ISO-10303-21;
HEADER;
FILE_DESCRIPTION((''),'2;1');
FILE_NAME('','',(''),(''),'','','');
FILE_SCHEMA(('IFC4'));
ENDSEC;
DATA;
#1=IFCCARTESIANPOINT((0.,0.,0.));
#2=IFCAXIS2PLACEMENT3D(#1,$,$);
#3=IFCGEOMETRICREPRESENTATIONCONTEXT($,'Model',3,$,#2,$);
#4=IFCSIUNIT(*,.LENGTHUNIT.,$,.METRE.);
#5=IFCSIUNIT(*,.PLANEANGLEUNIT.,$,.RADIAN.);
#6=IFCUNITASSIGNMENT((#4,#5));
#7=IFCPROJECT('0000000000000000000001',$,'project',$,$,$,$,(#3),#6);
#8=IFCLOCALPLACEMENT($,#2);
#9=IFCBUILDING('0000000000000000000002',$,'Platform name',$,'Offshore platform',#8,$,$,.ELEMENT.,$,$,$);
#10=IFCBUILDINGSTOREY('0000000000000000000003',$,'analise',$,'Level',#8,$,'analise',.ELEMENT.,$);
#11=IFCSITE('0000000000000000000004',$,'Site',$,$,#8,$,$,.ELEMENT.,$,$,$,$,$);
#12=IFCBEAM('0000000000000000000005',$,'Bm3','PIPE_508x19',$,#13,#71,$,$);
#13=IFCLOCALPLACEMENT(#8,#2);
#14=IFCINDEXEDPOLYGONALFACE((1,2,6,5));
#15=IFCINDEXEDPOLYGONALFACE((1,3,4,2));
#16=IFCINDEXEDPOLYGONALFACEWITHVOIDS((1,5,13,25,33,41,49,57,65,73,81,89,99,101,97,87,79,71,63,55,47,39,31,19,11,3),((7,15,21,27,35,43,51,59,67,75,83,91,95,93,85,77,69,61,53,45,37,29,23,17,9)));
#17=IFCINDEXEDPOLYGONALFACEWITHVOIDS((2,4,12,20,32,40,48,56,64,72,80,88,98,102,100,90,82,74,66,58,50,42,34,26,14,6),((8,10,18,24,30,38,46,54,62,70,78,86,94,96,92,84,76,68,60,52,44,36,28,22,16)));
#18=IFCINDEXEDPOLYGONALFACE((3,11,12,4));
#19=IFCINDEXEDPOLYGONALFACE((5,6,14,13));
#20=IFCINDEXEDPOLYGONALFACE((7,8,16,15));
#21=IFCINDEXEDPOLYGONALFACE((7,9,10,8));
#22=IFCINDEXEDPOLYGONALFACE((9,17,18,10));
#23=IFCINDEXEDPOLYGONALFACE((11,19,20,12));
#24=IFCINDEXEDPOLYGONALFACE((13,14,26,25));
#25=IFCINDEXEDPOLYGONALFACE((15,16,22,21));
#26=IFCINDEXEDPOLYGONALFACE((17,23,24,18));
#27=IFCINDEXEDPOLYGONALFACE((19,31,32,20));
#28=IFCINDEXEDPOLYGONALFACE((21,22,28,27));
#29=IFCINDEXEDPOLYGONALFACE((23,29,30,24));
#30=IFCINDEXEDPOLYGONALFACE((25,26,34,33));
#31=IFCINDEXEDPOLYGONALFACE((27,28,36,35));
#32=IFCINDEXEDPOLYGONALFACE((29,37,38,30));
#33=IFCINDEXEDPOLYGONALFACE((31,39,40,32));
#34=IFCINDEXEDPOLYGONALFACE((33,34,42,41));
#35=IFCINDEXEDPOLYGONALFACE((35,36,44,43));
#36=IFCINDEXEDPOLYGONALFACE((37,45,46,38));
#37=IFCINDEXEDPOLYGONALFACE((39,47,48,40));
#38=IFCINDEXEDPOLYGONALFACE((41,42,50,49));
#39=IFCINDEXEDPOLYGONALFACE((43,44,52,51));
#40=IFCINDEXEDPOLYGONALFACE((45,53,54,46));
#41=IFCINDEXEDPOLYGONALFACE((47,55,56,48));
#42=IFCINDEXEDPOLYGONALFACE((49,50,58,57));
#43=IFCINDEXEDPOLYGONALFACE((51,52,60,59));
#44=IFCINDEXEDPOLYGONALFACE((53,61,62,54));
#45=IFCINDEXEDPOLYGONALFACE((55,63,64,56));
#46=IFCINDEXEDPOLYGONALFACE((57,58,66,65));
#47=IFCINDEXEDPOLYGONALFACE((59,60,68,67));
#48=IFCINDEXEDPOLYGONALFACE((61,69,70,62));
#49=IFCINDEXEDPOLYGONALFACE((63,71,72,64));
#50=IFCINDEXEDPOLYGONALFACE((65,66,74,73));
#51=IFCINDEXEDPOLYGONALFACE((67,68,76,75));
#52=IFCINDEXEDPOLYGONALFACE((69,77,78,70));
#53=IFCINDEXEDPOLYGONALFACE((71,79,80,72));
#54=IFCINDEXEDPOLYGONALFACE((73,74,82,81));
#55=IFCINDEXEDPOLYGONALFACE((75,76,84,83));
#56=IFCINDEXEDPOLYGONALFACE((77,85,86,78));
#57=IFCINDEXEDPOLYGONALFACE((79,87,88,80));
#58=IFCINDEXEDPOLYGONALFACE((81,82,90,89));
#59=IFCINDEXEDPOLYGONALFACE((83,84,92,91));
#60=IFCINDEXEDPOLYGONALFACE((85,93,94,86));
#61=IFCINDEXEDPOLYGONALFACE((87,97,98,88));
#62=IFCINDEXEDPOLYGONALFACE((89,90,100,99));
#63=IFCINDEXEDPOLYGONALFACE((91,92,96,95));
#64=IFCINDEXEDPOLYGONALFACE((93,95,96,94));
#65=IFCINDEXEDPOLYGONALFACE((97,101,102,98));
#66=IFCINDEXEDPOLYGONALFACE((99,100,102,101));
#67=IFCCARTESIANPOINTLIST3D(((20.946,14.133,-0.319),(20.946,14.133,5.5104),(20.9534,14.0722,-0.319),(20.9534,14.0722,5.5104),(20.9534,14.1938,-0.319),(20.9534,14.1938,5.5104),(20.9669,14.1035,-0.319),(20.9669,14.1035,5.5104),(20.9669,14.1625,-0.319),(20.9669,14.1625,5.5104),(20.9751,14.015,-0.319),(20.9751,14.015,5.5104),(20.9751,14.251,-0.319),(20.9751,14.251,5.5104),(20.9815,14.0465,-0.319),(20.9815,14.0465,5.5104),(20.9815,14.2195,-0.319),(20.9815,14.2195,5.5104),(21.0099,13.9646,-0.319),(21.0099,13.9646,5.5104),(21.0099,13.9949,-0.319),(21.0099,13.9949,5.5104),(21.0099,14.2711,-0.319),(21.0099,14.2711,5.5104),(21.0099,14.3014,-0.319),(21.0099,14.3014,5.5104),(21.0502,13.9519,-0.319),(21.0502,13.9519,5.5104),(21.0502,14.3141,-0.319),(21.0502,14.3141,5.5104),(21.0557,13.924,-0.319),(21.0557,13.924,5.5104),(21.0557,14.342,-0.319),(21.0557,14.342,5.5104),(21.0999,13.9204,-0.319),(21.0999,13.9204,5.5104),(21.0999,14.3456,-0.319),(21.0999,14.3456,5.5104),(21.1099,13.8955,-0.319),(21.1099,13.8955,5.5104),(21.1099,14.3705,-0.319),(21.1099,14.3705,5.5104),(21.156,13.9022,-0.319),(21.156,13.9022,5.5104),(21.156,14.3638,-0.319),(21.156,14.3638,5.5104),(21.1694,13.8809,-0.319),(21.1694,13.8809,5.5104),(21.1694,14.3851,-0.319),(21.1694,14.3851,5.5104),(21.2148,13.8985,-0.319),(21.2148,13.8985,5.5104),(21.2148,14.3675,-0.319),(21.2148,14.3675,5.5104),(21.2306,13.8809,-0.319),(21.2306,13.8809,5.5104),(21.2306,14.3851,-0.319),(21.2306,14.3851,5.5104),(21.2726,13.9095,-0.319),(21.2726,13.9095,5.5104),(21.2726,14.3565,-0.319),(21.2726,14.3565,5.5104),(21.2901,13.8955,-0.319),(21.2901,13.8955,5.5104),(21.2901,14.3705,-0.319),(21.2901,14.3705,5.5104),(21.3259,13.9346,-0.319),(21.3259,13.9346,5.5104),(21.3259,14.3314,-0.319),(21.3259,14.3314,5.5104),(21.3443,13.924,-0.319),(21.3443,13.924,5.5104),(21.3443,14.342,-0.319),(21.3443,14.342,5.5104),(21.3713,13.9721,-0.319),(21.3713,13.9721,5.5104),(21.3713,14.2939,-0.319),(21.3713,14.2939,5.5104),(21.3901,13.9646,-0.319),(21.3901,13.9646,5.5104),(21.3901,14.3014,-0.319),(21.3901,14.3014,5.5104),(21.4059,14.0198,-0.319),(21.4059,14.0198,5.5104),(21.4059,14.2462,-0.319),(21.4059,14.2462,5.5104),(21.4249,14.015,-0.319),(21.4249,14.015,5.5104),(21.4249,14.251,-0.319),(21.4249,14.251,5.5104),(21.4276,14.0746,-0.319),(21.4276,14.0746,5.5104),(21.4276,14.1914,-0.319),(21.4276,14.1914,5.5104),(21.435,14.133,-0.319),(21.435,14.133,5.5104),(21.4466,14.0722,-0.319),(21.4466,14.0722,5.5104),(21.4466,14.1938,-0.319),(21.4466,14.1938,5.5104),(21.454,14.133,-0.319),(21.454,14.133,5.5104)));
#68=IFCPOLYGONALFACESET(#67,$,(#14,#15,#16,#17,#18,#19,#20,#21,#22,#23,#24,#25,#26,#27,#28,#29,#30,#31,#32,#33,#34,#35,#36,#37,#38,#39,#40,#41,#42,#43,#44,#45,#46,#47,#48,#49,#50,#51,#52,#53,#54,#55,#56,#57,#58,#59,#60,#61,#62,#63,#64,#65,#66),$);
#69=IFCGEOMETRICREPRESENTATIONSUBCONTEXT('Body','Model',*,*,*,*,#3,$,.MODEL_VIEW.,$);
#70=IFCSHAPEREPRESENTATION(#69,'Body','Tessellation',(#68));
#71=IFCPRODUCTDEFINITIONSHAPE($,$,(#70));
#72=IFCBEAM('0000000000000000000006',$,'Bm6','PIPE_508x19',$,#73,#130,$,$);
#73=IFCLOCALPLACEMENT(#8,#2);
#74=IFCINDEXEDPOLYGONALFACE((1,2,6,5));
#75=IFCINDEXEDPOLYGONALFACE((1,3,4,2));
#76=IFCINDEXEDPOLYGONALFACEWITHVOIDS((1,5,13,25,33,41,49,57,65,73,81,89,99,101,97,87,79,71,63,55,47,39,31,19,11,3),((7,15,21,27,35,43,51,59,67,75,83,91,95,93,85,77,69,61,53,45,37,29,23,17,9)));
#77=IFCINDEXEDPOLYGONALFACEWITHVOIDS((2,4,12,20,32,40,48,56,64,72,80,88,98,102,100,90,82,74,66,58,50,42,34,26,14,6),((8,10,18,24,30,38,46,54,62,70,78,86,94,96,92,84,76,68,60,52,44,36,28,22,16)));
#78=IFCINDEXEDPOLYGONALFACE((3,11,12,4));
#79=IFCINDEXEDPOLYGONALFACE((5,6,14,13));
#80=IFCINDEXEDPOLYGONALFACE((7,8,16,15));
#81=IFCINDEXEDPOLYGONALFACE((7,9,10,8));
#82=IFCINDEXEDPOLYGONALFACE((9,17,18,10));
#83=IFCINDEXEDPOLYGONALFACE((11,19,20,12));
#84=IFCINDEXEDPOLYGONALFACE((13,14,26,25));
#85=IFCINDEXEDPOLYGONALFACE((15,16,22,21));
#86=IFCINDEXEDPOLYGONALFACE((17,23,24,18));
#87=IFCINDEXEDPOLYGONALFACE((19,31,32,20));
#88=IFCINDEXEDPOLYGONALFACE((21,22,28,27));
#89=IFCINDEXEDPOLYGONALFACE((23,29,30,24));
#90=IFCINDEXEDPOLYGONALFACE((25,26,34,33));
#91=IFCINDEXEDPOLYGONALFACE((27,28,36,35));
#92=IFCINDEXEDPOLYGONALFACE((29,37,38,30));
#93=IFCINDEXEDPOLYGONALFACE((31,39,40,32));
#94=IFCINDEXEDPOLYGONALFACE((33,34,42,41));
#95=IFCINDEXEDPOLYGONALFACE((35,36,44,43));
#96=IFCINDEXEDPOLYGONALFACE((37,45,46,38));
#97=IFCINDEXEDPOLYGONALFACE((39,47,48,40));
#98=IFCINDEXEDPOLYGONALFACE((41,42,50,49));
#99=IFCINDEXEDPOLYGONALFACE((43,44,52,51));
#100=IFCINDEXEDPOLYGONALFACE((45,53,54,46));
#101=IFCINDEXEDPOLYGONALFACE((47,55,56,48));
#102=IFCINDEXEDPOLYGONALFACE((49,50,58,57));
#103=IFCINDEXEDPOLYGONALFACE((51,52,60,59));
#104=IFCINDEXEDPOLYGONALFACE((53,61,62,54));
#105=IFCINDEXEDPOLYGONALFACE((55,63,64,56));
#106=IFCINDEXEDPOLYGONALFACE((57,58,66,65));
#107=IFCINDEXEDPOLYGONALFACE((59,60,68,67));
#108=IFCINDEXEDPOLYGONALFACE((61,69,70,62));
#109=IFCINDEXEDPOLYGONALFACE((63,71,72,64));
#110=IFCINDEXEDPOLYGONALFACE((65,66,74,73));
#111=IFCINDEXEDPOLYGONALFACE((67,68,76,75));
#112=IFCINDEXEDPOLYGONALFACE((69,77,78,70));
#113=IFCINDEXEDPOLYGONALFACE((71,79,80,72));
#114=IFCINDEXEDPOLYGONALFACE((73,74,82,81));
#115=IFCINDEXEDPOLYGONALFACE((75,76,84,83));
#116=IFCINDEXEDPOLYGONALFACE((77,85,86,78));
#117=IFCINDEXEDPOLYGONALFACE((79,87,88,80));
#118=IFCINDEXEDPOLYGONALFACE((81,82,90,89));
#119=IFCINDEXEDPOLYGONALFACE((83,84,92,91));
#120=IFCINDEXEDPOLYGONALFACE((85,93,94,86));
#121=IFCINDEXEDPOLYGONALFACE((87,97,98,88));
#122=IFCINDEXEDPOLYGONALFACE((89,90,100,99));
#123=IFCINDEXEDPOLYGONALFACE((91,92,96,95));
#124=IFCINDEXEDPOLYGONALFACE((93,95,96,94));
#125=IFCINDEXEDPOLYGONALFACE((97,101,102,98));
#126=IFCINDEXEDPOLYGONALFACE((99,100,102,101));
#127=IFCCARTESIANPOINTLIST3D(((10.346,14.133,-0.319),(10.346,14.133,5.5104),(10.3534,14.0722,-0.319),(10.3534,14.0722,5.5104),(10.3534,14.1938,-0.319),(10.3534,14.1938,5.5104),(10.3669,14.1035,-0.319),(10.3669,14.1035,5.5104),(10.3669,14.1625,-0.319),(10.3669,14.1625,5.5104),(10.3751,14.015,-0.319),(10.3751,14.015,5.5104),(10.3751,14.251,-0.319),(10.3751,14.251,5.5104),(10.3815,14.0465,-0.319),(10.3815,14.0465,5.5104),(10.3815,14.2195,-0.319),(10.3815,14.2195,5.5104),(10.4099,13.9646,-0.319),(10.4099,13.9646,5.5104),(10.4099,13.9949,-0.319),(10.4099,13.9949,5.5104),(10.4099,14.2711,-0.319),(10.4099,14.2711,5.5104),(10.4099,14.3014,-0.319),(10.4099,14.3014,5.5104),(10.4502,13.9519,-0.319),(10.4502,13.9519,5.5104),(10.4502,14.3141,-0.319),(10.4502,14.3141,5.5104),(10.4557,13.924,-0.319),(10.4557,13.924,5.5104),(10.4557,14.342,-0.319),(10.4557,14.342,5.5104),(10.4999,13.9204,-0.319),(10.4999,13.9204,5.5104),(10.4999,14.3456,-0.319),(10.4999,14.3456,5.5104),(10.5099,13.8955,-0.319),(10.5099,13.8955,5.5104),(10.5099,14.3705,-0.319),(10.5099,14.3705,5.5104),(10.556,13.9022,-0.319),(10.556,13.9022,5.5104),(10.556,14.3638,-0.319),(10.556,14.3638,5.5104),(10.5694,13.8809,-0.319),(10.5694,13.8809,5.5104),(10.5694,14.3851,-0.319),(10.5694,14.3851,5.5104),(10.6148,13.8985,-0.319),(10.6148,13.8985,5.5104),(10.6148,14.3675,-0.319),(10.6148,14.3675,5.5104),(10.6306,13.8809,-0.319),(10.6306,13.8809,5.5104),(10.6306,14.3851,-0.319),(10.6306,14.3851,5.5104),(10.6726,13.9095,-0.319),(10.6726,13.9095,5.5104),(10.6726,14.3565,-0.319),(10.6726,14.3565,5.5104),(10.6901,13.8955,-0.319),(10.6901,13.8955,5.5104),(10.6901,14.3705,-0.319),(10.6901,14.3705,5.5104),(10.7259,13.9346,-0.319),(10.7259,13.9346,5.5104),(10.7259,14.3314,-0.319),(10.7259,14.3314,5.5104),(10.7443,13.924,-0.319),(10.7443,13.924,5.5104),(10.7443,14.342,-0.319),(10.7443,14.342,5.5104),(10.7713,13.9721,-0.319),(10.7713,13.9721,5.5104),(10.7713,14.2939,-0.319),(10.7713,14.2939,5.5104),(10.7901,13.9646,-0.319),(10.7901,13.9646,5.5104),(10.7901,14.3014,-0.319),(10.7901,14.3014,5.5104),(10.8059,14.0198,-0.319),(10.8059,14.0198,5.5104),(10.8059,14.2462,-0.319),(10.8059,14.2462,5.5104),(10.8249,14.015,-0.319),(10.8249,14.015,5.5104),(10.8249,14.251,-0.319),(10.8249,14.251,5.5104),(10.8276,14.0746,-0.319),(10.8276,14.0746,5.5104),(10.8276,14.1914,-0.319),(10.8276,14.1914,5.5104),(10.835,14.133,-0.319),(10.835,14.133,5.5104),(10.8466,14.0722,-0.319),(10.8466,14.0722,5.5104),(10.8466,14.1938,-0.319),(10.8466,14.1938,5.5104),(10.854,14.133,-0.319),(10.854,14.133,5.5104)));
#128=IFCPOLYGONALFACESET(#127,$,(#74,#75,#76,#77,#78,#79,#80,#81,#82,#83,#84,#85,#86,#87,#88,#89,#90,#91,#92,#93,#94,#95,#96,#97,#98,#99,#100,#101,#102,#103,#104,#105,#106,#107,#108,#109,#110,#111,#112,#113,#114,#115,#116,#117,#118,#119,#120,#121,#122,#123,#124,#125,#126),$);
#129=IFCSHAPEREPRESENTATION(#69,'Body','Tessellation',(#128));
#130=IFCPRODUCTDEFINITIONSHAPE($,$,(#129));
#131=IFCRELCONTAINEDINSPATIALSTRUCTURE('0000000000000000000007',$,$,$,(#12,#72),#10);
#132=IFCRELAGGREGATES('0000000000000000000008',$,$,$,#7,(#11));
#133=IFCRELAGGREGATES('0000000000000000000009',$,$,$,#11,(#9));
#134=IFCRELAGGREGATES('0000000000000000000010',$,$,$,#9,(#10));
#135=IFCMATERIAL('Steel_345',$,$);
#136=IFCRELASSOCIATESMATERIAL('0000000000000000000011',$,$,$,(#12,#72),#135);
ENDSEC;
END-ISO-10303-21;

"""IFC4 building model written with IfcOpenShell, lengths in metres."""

from ifc_helpers import new_model, si_unit, frame, origin, origin_with_axes, origin_2d, place, context, subcontext, project, spatial, hollow_circle, extrude, source, transform, mapped, material, element, save


model = new_model("IFC4")

# Units and contexts
model_context = context("Model", 3, world=origin())
body_context = subcontext(model_context, "Body", "Model", "MODEL_VIEW")
ifc_project = project(units=[si_unit("LENGTHUNIT", "METRE"), si_unit("PLANEANGLEUNIT", "RADIAN")], contexts=[model_context])

# Site, building, storey
placement_1 = place(None, origin())
site = spatial("IfcSite", under=ifc_project, at=placement_1, Name="Site", CompositionType="ELEMENT")
building = spatial("IfcBuilding", under=site, at=placement_1, Name="Platform name", ObjectType="Offshore platform", CompositionType="ELEMENT")
storey = spatial("IfcBuildingStorey", under=building, at=placement_1, Name="analise", ObjectType="Level", LongName="analise", CompositionType="ELEMENT")

# Beams
ifc_material_1 = material(Name="Steel_345")
shared_shape_1 = source(origin(), body_context, "Body", "SweptSolid", [
    extrude(hollow_circle(Radius=0.254, WallThickness=0.019, at=origin_2d()), origin_with_axes(), (0.0, 0.0, 1.0), 5.8293),
])
placement_2 = place(None, origin())
placement_3 = place(placement_2, origin())
placement_4 = place(placement_3, origin())
beam_1_placement = place(placement_4, frame((21.2, 14.133, -0.319)))
element("IfcBeam", 1, at=beam_1_placement, inside=storey, material=ifc_material_1, Name="Bm3", Description="PIPE_508x19", context=body_context, shape_type="MappedRepresentation", body=[
    mapped(shared_shape_1, transform((0.0, 0.0, 0.0), scale=1.0)),
])
shared_shape_2 = source(origin(), body_context, "Body", "SweptSolid", [
    extrude(hollow_circle(Radius=0.254, WallThickness=0.019, at=origin_2d()), origin_with_axes(), (0.0, 0.0, 1.0), 5.8293),
])
placement_5 = place(None, origin())
placement_6 = place(placement_5, origin())
placement_7 = place(placement_6, origin())
beam_2_placement = place(placement_7, frame((10.6, 14.133, -0.319)))
element("IfcBeam", 2, at=beam_2_placement, inside=storey, material=ifc_material_1, Name="Bm6", Description="PIPE_508x19", context=body_context, shape_type="MappedRepresentation", body=[
    mapped(shared_shape_2, transform((0.0, 0.0, 0.0), scale=1.0)),
])

save(model, "model.ifc")
